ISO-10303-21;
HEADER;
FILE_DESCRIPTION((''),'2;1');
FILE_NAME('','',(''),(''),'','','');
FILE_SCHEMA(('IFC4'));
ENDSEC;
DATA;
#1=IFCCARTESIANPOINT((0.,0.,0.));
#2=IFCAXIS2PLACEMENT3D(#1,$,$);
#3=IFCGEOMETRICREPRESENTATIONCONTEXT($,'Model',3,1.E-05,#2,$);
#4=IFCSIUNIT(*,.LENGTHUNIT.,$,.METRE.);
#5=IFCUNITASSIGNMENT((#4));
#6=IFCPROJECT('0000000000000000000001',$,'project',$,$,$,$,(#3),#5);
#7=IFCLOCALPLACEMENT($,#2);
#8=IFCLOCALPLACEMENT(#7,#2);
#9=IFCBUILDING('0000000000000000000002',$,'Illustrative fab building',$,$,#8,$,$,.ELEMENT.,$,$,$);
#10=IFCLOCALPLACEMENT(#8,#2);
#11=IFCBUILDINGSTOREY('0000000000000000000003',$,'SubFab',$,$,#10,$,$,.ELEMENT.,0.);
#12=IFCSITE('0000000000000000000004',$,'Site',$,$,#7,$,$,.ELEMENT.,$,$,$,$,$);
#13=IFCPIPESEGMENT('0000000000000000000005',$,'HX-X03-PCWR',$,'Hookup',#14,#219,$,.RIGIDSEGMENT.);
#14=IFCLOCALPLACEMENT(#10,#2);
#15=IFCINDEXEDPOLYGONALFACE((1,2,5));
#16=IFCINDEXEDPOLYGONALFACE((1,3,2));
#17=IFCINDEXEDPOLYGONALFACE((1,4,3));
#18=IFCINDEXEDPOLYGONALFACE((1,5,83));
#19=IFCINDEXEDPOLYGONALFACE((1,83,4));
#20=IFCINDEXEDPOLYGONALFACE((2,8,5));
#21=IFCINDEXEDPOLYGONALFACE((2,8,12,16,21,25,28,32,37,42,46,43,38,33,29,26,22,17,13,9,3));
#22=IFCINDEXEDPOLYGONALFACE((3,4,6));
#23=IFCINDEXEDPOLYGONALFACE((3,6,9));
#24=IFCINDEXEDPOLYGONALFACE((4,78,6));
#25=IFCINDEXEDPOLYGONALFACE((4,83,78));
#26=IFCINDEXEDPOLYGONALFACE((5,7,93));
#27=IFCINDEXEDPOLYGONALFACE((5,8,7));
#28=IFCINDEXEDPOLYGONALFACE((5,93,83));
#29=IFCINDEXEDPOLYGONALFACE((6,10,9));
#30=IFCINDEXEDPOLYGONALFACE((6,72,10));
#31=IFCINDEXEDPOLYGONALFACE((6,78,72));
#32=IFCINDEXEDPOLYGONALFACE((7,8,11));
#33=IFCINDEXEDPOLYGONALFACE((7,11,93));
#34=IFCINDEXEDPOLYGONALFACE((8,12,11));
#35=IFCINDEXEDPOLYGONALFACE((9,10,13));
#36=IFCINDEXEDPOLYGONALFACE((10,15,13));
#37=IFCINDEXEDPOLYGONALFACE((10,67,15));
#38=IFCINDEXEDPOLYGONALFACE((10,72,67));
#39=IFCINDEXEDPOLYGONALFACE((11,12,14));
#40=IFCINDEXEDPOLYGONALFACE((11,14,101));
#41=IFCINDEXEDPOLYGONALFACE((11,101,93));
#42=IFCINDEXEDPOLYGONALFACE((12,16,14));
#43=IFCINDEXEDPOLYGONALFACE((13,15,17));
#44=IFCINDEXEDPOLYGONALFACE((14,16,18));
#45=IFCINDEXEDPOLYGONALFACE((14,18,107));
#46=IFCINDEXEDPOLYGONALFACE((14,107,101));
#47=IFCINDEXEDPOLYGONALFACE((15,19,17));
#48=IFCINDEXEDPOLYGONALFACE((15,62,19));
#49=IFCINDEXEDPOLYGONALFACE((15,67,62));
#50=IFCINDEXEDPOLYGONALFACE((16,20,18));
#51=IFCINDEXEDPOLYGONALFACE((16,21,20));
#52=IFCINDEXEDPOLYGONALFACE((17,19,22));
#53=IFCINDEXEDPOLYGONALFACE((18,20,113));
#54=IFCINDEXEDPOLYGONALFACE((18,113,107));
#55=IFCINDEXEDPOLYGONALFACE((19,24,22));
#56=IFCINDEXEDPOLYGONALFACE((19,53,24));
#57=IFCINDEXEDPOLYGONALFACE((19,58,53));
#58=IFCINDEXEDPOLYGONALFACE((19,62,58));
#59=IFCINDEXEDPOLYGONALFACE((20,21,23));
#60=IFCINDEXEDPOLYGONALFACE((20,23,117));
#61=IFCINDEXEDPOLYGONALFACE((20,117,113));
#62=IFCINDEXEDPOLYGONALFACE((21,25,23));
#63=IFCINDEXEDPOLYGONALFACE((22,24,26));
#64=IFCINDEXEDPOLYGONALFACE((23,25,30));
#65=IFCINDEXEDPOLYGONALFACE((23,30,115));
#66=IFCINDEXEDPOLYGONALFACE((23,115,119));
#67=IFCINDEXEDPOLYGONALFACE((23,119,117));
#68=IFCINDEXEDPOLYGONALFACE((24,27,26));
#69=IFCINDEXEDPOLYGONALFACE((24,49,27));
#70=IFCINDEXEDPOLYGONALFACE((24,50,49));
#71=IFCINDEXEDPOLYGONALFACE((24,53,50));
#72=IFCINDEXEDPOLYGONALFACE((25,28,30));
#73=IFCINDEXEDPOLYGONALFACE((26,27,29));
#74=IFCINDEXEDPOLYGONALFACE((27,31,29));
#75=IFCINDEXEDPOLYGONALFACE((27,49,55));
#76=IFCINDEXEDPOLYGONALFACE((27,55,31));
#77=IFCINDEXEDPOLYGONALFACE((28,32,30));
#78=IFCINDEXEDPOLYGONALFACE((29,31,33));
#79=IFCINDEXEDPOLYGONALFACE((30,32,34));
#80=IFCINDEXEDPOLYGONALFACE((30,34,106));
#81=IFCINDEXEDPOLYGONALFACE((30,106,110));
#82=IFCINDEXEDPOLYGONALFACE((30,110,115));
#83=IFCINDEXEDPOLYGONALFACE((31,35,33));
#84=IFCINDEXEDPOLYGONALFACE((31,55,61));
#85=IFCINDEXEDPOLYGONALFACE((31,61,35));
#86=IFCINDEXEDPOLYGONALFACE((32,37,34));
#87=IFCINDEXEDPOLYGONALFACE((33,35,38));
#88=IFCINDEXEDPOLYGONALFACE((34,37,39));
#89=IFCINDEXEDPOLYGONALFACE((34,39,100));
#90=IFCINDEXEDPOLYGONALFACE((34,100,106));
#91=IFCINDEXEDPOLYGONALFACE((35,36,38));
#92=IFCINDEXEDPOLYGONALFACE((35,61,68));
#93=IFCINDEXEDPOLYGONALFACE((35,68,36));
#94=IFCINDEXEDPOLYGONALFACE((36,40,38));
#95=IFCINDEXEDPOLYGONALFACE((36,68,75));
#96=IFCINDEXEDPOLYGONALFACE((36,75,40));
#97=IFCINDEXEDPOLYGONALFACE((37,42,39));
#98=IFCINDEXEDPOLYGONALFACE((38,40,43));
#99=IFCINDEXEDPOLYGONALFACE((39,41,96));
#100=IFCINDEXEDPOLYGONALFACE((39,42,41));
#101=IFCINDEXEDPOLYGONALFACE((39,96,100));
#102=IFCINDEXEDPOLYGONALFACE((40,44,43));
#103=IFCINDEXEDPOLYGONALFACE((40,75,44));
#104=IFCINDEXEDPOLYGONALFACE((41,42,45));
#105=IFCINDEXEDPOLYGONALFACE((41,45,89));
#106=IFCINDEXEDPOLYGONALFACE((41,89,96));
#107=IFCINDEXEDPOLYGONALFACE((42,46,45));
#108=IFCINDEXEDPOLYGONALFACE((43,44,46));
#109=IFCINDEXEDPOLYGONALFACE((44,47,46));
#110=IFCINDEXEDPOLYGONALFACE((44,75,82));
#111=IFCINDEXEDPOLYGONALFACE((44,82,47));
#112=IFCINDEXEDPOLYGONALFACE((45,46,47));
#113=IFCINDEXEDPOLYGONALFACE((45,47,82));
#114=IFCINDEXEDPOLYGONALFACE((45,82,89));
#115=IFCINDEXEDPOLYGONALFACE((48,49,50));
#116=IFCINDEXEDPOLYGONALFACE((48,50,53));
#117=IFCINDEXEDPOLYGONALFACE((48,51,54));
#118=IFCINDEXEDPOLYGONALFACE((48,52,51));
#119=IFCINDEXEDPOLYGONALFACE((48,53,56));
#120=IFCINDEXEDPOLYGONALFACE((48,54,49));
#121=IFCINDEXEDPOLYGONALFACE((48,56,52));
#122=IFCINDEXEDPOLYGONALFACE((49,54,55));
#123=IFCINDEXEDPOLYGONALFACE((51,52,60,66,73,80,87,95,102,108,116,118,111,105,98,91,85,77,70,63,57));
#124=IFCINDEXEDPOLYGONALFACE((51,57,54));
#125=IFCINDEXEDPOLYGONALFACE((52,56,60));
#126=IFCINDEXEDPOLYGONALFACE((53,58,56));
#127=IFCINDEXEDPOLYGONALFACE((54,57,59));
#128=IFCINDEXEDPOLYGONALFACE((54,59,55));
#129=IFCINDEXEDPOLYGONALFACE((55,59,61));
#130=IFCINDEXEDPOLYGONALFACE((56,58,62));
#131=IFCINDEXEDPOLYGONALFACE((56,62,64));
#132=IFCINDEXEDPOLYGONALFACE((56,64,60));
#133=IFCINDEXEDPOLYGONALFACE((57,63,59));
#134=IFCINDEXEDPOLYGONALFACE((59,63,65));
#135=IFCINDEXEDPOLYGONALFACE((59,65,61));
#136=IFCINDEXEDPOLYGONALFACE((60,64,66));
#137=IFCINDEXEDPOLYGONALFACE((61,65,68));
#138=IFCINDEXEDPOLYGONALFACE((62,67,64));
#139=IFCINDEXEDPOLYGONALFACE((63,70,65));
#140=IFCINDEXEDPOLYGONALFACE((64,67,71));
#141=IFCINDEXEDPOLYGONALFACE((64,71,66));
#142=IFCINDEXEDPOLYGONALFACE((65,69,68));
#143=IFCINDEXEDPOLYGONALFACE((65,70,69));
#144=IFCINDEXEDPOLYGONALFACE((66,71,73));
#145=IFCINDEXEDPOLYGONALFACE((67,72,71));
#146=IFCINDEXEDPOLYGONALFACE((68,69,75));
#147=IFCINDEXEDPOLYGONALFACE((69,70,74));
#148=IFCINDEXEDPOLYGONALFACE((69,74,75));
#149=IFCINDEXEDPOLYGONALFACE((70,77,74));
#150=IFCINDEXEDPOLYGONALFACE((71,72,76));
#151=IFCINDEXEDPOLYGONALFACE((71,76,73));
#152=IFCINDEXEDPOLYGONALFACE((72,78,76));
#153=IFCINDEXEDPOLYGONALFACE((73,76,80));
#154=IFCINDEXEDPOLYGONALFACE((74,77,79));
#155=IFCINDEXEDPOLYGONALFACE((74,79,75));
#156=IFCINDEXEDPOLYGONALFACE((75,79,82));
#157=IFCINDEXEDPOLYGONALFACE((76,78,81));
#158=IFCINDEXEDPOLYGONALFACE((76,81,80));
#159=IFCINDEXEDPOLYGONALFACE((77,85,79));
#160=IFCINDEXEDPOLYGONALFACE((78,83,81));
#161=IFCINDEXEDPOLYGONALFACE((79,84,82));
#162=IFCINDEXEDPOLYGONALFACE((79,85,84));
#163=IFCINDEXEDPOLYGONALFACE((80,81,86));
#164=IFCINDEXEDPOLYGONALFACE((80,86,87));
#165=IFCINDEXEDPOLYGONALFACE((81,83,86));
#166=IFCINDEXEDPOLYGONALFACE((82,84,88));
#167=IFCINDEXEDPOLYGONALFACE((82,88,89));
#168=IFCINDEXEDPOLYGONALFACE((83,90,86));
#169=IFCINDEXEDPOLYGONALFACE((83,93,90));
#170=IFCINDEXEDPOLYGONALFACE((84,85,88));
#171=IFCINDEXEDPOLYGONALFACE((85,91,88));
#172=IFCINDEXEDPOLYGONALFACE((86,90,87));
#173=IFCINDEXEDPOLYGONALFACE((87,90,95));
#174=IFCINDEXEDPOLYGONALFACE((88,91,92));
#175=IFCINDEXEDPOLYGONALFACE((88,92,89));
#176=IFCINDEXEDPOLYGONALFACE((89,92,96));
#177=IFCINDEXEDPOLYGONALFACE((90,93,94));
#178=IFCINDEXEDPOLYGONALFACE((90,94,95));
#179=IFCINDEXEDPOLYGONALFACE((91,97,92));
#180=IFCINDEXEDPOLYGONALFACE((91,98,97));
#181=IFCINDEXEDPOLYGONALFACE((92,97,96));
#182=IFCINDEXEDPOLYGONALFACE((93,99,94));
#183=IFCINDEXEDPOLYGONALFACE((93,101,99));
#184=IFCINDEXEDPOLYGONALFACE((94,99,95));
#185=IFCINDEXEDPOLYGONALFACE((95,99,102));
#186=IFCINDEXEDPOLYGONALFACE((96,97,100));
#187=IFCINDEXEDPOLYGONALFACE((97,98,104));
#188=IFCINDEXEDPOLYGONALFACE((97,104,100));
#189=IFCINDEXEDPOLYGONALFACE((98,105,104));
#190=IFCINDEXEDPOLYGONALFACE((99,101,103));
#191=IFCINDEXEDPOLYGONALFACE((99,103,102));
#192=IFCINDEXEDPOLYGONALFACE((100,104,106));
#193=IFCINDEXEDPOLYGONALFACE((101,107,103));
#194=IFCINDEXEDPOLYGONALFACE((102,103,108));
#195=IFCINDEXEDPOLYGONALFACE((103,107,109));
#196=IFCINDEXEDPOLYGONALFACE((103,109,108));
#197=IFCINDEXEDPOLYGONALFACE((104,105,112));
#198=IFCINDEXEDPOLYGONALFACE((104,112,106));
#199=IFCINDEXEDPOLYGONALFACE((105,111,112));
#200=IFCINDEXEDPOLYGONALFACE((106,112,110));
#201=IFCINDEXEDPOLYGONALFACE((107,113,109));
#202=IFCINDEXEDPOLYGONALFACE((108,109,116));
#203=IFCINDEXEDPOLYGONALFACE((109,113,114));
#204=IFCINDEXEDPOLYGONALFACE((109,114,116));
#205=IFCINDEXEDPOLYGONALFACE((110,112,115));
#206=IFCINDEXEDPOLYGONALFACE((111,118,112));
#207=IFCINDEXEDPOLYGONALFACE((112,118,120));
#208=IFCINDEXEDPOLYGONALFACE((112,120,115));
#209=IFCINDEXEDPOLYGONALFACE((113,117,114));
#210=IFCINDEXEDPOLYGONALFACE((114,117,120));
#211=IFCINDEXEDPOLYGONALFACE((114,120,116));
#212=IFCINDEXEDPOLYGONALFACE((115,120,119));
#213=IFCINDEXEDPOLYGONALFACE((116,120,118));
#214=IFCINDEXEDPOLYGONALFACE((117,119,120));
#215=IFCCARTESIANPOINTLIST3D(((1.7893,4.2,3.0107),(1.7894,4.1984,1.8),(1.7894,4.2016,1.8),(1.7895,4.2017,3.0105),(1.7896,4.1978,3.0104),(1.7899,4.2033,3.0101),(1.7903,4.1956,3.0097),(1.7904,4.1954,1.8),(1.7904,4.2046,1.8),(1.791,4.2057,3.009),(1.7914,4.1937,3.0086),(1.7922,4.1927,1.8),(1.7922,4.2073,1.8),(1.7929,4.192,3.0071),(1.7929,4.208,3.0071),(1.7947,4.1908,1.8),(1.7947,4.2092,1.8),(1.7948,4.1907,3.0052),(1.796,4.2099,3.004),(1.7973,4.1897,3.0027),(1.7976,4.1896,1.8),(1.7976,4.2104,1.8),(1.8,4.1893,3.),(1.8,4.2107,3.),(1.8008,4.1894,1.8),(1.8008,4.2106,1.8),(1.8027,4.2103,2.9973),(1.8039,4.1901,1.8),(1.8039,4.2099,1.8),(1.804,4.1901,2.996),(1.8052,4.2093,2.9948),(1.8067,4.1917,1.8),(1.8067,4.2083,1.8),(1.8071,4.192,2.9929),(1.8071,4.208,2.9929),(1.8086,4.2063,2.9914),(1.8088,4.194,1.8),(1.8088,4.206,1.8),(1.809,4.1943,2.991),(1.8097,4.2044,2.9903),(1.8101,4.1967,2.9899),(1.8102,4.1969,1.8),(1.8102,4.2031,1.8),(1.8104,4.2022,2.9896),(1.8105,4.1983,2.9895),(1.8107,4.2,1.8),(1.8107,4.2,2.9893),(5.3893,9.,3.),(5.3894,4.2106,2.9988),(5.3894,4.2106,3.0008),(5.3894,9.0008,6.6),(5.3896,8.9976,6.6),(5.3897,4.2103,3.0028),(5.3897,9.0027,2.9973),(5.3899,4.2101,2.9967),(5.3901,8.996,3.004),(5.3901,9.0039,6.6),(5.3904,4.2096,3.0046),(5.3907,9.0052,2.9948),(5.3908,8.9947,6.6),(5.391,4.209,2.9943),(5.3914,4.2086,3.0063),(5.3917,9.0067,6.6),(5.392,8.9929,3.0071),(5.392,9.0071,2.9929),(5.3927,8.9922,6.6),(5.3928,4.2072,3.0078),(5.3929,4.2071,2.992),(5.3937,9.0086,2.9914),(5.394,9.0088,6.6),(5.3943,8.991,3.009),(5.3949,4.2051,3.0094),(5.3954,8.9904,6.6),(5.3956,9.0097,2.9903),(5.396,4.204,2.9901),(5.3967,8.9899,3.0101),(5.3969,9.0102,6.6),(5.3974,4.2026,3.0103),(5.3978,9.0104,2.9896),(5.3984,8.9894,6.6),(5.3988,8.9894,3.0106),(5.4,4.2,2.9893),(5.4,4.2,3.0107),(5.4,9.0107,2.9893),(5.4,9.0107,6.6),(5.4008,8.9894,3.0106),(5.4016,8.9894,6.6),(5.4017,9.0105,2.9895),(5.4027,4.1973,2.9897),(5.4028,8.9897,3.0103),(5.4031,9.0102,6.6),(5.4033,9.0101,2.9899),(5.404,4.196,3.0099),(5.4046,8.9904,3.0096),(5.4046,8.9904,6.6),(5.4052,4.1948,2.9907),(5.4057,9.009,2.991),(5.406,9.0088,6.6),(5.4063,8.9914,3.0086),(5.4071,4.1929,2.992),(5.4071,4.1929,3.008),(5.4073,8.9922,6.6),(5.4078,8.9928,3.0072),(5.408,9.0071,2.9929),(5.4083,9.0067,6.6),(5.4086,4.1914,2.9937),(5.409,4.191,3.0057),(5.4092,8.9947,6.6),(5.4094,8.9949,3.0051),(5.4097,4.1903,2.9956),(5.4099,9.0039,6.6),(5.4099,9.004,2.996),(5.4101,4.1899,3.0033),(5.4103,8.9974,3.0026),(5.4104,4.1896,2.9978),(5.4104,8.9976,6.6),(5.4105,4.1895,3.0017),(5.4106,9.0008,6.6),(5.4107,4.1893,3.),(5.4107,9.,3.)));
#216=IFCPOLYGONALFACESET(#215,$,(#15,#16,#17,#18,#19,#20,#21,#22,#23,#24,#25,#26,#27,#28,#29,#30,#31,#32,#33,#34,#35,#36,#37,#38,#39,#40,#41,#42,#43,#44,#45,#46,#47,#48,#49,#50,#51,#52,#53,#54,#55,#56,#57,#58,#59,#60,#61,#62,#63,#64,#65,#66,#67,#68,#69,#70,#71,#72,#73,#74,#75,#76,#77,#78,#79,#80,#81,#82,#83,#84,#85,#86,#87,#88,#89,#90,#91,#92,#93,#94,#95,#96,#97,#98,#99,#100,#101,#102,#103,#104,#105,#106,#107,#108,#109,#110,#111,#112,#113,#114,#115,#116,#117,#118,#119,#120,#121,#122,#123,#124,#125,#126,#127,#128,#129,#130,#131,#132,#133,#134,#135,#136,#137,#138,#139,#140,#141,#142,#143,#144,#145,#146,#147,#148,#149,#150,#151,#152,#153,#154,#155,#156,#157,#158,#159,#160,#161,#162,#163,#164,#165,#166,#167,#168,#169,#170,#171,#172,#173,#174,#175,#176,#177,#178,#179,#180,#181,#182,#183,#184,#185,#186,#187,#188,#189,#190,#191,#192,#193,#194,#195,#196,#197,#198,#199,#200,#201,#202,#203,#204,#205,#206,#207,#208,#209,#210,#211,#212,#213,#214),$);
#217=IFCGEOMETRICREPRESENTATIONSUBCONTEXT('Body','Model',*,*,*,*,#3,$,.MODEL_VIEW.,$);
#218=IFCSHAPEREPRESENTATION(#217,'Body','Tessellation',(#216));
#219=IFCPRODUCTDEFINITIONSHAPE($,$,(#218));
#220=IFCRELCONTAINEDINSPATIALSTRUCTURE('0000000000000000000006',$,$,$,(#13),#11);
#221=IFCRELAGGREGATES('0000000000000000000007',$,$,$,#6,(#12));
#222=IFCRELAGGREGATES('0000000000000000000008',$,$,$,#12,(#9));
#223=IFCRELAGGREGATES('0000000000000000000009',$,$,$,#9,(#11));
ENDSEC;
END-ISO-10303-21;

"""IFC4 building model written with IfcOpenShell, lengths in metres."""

from ifc_helpers import new_model, entity, si_unit, origin, place, context, subcontext, project, spatial, element, save


model = new_model("IFC4")

# Units and contexts
model_context = context("Model", 3, precision=1e-05, world=origin())
body_context = subcontext(model_context, "Body", "Model", "MODEL_VIEW")
ifc_project = project(units=[si_unit("LENGTHUNIT", "METRE")], contexts=[model_context])

# Site, building, storey
site_placement = place(None, origin())
site = spatial("IfcSite", under=ifc_project, at=site_placement, Name="Site", CompositionType="ELEMENT")
building_placement = place(site_placement, origin())
building = spatial("IfcBuilding", under=site, at=building_placement, Name="Illustrative fab building", CompositionType="ELEMENT")
storey_placement = place(building_placement, origin())
storey = spatial("IfcBuildingStorey", under=building, at=storey_placement, Name="SubFab", CompositionType="ELEMENT", Elevation=0.0)

# Pipe segment
pipe_segment_1_placement = place(storey_placement, origin())
element("IfcPipeSegment", 1, at=pipe_segment_1_placement, inside=storey, Name="HX-X03-PCWR", ObjectType="Hookup", PredefinedType="RIGIDSEGMENT", context=body_context, shape_type="AdvancedSweptSolid", body=[
    entity("IfcSweptDiskSolid", entity("IfcPolyline", [entity("IfcCartesianPoint", [1.8, 4.2, 1.8]), entity("IfcCartesianPoint", [1.8, 4.2, 3.0]), entity("IfcCartesianPoint", [5.4, 4.2, 3.0]), entity("IfcCartesianPoint", [5.4, 9.0, 3.0]), entity("IfcCartesianPoint", [5.4, 9.0, 6.6])]), 0.0107),
])

save(model, "model.ifc")
